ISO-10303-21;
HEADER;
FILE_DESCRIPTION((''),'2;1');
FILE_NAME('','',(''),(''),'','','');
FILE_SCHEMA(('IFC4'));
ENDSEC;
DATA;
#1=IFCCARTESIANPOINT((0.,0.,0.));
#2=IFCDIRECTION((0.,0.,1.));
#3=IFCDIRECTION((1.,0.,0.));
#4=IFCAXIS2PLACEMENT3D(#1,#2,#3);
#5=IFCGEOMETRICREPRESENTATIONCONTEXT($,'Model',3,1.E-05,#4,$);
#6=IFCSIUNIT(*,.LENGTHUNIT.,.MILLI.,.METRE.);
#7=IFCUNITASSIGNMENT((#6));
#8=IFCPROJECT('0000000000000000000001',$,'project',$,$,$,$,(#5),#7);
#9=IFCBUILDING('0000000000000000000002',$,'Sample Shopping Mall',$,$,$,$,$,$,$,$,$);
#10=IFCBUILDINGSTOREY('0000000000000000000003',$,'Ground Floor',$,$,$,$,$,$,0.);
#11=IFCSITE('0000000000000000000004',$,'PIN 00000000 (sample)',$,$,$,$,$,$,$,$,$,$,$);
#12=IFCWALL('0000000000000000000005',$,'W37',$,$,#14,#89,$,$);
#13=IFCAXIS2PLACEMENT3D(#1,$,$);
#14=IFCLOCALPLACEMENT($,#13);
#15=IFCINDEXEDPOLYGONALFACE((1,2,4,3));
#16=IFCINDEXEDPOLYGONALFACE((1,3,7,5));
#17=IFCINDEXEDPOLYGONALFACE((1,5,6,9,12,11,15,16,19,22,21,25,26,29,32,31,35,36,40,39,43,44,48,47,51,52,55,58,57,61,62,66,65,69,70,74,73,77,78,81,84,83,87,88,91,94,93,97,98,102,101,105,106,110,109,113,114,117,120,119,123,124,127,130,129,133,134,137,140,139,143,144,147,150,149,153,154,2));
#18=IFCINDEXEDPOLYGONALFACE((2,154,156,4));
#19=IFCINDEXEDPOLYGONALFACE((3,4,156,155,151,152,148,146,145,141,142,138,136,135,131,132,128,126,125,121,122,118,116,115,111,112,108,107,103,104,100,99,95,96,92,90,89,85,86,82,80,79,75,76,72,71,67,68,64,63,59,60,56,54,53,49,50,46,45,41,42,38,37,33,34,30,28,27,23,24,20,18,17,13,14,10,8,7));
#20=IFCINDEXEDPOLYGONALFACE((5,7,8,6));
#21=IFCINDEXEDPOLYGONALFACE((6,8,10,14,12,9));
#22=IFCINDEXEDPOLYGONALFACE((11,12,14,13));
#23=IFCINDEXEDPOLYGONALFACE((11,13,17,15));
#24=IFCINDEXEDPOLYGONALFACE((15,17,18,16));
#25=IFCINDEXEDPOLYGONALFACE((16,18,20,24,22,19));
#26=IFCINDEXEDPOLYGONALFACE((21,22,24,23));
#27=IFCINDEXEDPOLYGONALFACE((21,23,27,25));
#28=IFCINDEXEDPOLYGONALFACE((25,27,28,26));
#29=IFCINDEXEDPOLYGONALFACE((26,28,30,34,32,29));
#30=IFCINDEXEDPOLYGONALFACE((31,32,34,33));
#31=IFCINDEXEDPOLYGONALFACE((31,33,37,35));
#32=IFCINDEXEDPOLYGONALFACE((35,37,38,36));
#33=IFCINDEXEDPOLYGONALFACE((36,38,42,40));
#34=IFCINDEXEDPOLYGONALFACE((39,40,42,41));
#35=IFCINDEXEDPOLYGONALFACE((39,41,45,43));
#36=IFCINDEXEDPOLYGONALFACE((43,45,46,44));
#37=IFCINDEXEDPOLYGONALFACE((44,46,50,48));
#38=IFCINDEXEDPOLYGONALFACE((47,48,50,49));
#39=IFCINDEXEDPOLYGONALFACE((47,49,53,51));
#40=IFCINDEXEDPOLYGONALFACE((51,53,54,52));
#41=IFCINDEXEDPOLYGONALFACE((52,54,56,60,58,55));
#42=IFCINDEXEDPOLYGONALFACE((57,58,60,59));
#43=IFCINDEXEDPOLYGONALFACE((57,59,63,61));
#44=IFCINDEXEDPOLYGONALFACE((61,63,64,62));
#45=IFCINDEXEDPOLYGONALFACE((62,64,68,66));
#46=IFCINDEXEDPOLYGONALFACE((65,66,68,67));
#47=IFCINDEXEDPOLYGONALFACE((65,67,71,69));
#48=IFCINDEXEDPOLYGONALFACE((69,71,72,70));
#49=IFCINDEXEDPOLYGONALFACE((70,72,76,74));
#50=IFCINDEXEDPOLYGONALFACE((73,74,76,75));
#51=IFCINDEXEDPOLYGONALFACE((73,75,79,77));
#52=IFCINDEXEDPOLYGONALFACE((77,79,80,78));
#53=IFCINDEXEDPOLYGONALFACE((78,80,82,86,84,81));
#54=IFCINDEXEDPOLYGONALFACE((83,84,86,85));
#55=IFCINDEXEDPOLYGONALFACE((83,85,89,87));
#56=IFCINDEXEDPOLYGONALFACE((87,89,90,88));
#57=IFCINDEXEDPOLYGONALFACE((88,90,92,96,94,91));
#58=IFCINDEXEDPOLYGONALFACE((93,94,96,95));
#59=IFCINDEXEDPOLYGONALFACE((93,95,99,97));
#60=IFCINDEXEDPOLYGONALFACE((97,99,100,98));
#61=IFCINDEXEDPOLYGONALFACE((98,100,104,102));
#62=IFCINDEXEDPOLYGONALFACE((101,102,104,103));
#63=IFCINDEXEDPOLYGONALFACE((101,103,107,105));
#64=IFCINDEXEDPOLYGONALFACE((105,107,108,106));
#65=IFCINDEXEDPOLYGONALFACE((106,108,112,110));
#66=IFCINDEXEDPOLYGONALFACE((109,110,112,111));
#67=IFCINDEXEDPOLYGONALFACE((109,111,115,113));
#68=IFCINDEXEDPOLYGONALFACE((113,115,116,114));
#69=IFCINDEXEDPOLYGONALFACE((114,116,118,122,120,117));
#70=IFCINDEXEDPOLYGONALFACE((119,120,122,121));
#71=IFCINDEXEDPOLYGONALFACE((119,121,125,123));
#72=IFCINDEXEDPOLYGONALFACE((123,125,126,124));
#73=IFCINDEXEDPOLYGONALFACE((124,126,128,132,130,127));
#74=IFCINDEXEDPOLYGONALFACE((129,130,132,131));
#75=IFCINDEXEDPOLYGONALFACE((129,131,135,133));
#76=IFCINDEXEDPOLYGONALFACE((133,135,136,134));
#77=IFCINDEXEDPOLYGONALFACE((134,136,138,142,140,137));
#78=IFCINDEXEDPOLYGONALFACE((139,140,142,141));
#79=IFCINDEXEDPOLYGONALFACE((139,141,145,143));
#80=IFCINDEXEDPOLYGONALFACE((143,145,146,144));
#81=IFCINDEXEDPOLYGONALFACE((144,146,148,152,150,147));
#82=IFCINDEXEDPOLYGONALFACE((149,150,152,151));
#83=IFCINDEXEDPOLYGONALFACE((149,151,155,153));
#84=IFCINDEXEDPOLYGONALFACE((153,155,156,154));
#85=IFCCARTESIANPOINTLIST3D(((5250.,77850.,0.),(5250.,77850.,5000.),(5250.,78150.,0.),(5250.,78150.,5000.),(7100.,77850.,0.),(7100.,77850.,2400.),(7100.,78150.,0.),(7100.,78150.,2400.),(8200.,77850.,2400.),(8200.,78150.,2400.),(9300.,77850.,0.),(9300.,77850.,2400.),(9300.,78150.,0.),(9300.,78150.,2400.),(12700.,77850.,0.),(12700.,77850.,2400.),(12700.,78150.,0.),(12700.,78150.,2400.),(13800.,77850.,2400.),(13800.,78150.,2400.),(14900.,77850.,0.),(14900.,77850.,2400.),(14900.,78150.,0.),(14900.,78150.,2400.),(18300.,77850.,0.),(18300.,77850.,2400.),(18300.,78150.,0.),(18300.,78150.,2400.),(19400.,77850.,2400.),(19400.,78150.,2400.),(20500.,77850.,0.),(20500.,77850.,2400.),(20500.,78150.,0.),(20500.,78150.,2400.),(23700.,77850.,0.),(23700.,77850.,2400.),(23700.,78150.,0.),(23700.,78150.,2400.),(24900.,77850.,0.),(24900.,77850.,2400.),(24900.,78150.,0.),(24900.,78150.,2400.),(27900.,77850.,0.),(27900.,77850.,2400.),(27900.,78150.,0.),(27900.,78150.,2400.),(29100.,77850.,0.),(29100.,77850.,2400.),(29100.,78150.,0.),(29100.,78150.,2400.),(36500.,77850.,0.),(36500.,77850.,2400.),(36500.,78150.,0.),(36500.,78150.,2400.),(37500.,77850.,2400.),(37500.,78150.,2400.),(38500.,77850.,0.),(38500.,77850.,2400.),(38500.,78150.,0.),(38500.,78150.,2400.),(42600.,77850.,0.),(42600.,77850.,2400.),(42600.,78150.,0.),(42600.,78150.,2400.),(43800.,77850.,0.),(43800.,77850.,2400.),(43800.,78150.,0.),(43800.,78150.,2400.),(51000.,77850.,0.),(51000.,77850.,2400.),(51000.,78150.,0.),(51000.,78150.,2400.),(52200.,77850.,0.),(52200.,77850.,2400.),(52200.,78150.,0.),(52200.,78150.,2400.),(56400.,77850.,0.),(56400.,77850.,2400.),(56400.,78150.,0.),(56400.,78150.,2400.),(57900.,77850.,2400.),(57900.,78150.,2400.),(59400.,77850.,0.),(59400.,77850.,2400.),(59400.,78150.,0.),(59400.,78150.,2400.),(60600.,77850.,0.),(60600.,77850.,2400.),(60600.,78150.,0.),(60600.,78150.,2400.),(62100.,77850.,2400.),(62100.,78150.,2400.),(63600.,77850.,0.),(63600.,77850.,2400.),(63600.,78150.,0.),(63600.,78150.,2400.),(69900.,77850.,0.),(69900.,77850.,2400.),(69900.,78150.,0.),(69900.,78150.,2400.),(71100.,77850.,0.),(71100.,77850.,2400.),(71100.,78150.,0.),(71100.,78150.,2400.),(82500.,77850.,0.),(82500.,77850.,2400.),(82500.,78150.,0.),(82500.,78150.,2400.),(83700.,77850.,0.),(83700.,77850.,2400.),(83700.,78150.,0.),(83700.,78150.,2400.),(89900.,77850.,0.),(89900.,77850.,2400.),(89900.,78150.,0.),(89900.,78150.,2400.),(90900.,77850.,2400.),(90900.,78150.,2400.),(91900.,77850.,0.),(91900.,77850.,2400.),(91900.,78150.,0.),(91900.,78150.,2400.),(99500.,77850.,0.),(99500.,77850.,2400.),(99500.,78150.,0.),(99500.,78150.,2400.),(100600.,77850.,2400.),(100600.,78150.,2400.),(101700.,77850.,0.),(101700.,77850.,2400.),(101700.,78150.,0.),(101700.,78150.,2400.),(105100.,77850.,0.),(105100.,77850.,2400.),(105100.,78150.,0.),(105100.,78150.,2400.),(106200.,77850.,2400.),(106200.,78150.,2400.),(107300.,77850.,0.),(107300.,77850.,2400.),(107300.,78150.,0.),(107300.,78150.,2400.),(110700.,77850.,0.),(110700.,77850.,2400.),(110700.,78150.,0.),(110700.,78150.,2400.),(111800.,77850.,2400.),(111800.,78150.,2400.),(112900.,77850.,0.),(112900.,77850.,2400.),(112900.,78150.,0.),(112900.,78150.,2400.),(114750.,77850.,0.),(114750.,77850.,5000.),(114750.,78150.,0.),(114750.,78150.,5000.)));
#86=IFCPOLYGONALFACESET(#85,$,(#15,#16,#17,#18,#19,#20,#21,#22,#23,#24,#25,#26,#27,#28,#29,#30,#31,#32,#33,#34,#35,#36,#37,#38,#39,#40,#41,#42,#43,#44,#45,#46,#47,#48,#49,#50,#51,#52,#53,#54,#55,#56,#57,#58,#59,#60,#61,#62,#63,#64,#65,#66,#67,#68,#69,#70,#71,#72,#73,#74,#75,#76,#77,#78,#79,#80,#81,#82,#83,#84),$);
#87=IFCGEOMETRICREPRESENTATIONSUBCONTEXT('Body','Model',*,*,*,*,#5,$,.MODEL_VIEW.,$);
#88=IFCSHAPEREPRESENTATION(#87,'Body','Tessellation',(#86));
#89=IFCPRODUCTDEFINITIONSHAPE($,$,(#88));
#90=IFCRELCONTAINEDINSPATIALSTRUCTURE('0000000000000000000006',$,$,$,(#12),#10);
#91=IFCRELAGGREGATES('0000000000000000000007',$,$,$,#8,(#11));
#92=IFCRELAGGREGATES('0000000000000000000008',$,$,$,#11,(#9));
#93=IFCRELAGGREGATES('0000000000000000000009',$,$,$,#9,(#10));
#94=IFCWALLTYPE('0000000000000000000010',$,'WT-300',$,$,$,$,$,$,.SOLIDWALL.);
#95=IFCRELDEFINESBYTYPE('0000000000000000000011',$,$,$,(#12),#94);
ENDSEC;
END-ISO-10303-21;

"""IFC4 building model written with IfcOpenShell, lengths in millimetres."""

from ifc_helpers import new_model, si_unit, frame, origin_with_axes, place, context, subcontext, project, spatial, indexed_curve, outline, extrude, type_object, element, save


model = new_model("IFC4")

# Units and contexts
model_context = context("Model", 3, precision=1e-05, world=origin_with_axes())
body_context = subcontext(model_context, "Body", "Model", "MODEL_VIEW")
ifc_project = project(units=[si_unit("LENGTHUNIT", "METRE", prefix="MILLI")], contexts=[model_context])

# Site, building, storey
site = spatial("IfcSite", under=ifc_project, Name="PIN 00000000 (sample)")
building = spatial("IfcBuilding", under=site, Name="Sample Shopping Mall")
storey = spatial("IfcBuildingStorey", under=building, Name="Ground Floor", Elevation=0.0)

# Wall, openings
wall_type_1 = type_object("IfcWallType", Name="WT-300", PredefinedType="SOLIDWALL")
wall_1_placement = place(None, frame((5250.0, 77850.0, 0.0), z_axis=(0.0, 0.0, 1.0), x_axis=(1.0, 0.0, 0.0)))
wall_1 = element("IfcWall", 1, at=wall_1_placement, inside=storey, type_object=wall_type_1, Name="W37", context=body_context, shape_type="SweptSolid", body=[
    extrude(outline(indexed_curve([(0.0, 0.0), (0.0, 300.0), (109500.0, 300.0), (109500.0, 0.0), (0.0, 0.0)], self_intersect=False)), origin_with_axes(), (0.0, 0.0, 1.0), 5000.0),
])
opening_1_placement = place(wall_1_placement, frame((1850.0, -100.0, 0.0), z_axis=(0.0, 0.0, 1.0), x_axis=(1.0, 0.0, 0.0)))
element("IfcOpeningElement", 2, at=opening_1_placement, cuts=wall_1, context=body_context, shape_type="SweptSolid", body=[
    extrude(outline(indexed_curve([(0.0, 0.0), (0.0, 500.0), (1100.0, 500.0), (1100.0, 0.0), (0.0, 0.0)], self_intersect=False)), origin_with_axes(), (0.0, 0.0, 1.0), 2400.0),
])
opening_2_placement = place(wall_1_placement, frame((2950.0, -100.0, 0.0), z_axis=(0.0, 0.0, 1.0), x_axis=(1.0, 0.0, 0.0)))
element("IfcOpeningElement", 3, at=opening_2_placement, cuts=wall_1, context=body_context, shape_type="SweptSolid", body=[
    extrude(outline(indexed_curve([(0.0, 0.0), (0.0, 500.0), (1100.0, 500.0), (1100.0, 0.0), (0.0, 0.0)], self_intersect=False)), origin_with_axes(), (0.0, 0.0, 1.0), 2400.0),
])
opening_3_placement = place(wall_1_placement, frame((7450.0, -100.0, 0.0), z_axis=(0.0, 0.0, 1.0), x_axis=(1.0, 0.0, 0.0)))
element("IfcOpeningElement", 4, at=opening_3_placement, cuts=wall_1, context=body_context, shape_type="SweptSolid", body=[
    extrude(outline(indexed_curve([(0.0, 0.0), (0.0, 500.0), (1100.0, 500.0), (1100.0, 0.0), (0.0, 0.0)], self_intersect=False)), origin_with_axes(), (0.0, 0.0, 1.0), 2400.0),
])
opening_4_placement = place(wall_1_placement, frame((8550.0, -100.0, 0.0), z_axis=(0.0, 0.0, 1.0), x_axis=(1.0, 0.0, 0.0)))
element("IfcOpeningElement", 5, at=opening_4_placement, cuts=wall_1, context=body_context, shape_type="SweptSolid", body=[
    extrude(outline(indexed_curve([(0.0, 0.0), (0.0, 500.0), (1100.0, 500.0), (1100.0, 0.0), (0.0, 0.0)], self_intersect=False)), origin_with_axes(), (0.0, 0.0, 1.0), 2400.0),
])
opening_5_placement = place(wall_1_placement, frame((13050.0, -100.0, 0.0), z_axis=(0.0, 0.0, 1.0), x_axis=(1.0, 0.0, 0.0)))
element("IfcOpeningElement", 6, at=opening_5_placement, cuts=wall_1, context=body_context, shape_type="SweptSolid", body=[
    extrude(outline(indexed_curve([(0.0, 0.0), (0.0, 500.0), (1100.0, 500.0), (1100.0, 0.0), (0.0, 0.0)], self_intersect=False)), origin_with_axes(), (0.0, 0.0, 1.0), 2400.0),
])
opening_6_placement = place(wall_1_placement, frame((14150.0, -100.0, 0.0), z_axis=(0.0, 0.0, 1.0), x_axis=(1.0, 0.0, 0.0)))
element("IfcOpeningElement", 7, at=opening_6_placement, cuts=wall_1, context=body_context, shape_type="SweptSolid", body=[
    extrude(outline(indexed_curve([(0.0, 0.0), (0.0, 500.0), (1100.0, 500.0), (1100.0, 0.0), (0.0, 0.0)], self_intersect=False)), origin_with_axes(), (0.0, 0.0, 1.0), 2400.0),
])
opening_7_placement = place(wall_1_placement, frame((94250.0, -100.0, 0.0), z_axis=(0.0, 0.0, 1.0), x_axis=(1.0, 0.0, 0.0)))
element("IfcOpeningElement", 8, at=opening_7_placement, cuts=wall_1, context=body_context, shape_type="SweptSolid", body=[
    extrude(outline(indexed_curve([(0.0, 0.0), (0.0, 500.0), (1100.0, 500.0), (1100.0, 0.0), (0.0, 0.0)], self_intersect=False)), origin_with_axes(), (0.0, 0.0, 1.0), 2400.0),
])
opening_8_placement = place(wall_1_placement, frame((95350.0, -100.0, 0.0), z_axis=(0.0, 0.0, 1.0), x_axis=(1.0, 0.0, 0.0)))
element("IfcOpeningElement", 9, at=opening_8_placement, cuts=wall_1, context=body_context, shape_type="SweptSolid", body=[
    extrude(outline(indexed_curve([(0.0, 0.0), (0.0, 500.0), (1100.0, 500.0), (1100.0, 0.0), (0.0, 0.0)], self_intersect=False)), origin_with_axes(), (0.0, 0.0, 1.0), 2400.0),
])
opening_9_placement = place(wall_1_placement, frame((99850.0, -100.0, 0.0), z_axis=(0.0, 0.0, 1.0), x_axis=(1.0, 0.0, 0.0)))
element("IfcOpeningElement", 10, at=opening_9_placement, cuts=wall_1, context=body_context, shape_type="SweptSolid", body=[
    extrude(outline(indexed_curve([(0.0, 0.0), (0.0, 500.0), (1100.0, 500.0), (1100.0, 0.0), (0.0, 0.0)], self_intersect=False)), origin_with_axes(), (0.0, 0.0, 1.0), 2400.0),
])
opening_10_placement = place(wall_1_placement, frame((100950.0, -100.0, 0.0), z_axis=(0.0, 0.0, 1.0), x_axis=(1.0, 0.0, 0.0)))
element("IfcOpeningElement", 11, at=opening_10_placement, cuts=wall_1, context=body_context, shape_type="SweptSolid", body=[
    extrude(outline(indexed_curve([(0.0, 0.0), (0.0, 500.0), (1100.0, 500.0), (1100.0, 0.0), (0.0, 0.0)], self_intersect=False)), origin_with_axes(), (0.0, 0.0, 1.0), 2400.0),
])
opening_11_placement = place(wall_1_placement, frame((105450.0, -100.0, 0.0), z_axis=(0.0, 0.0, 1.0), x_axis=(1.0, 0.0, 0.0)))
element("IfcOpeningElement", 12, at=opening_11_placement, cuts=wall_1, context=body_context, shape_type="SweptSolid", body=[
    extrude(outline(indexed_curve([(0.0, 0.0), (0.0, 500.0), (1100.0, 500.0), (1100.0, 0.0), (0.0, 0.0)], self_intersect=False)), origin_with_axes(), (0.0, 0.0, 1.0), 2400.0),
])
opening_12_placement = place(wall_1_placement, frame((106550.0, -100.0, 0.0), z_axis=(0.0, 0.0, 1.0), x_axis=(1.0, 0.0, 0.0)))
element("IfcOpeningElement", 13, at=opening_12_placement, cuts=wall_1, context=body_context, shape_type="SweptSolid", body=[
    extrude(outline(indexed_curve([(0.0, 0.0), (0.0, 500.0), (1100.0, 500.0), (1100.0, 0.0), (0.0, 0.0)], self_intersect=False)), origin_with_axes(), (0.0, 0.0, 1.0), 2400.0),
])
opening_13_placement = place(wall_1_placement, frame((18450.0, -100.0, 0.0), z_axis=(0.0, 0.0, 1.0), x_axis=(1.0, 0.0, 0.0)))
element("IfcOpeningElement", 14, at=opening_13_placement, cuts=wall_1, context=body_context, shape_type="SweptSolid", body=[
    extrude(outline(indexed_curve([(0.0, 0.0), (0.0, 500.0), (1200.0, 500.0), (1200.0, 0.0), (0.0, 0.0)], self_intersect=False)), origin_with_axes(), (0.0, 0.0, 1.0), 2400.0),
])
opening_14_placement = place(wall_1_placement, frame((22650.0, -100.0, 0.0), z_axis=(0.0, 0.0, 1.0), x_axis=(1.0, 0.0, 0.0)))
element("IfcOpeningElement", 15, at=opening_14_placement, cuts=wall_1, context=body_context, shape_type="SweptSolid", body=[
    extrude(outline(indexed_curve([(0.0, 0.0), (0.0, 500.0), (1200.0, 500.0), (1200.0, 0.0), (0.0, 0.0)], self_intersect=False)), origin_with_axes(), (0.0, 0.0, 1.0), 2400.0),
])
opening_15_placement = place(wall_1_placement, frame((37350.0, -100.0, 0.0), z_axis=(0.0, 0.0, 1.0), x_axis=(1.0, 0.0, 0.0)))
element("IfcOpeningElement", 16, at=opening_15_placement, cuts=wall_1, context=body_context, shape_type="SweptSolid", body=[
    extrude(outline(indexed_curve([(0.0, 0.0), (0.0, 500.0), (1200.0, 500.0), (1200.0, 0.0), (0.0, 0.0)], self_intersect=False)), origin_with_axes(), (0.0, 0.0, 1.0), 2400.0),
])
opening_16_placement = place(wall_1_placement, frame((45750.0, -100.0, 0.0), z_axis=(0.0, 0.0, 1.0), x_axis=(1.0, 0.0, 0.0)))
element("IfcOpeningElement", 17, at=opening_16_placement, cuts=wall_1, context=body_context, shape_type="SweptSolid", body=[
    extrude(outline(indexed_curve([(0.0, 0.0), (0.0, 500.0), (1200.0, 500.0), (1200.0, 0.0), (0.0, 0.0)], self_intersect=False)), origin_with_axes(), (0.0, 0.0, 1.0), 2400.0),
])
opening_17_placement = place(wall_1_placement, frame((64650.0, -100.0, 0.0), z_axis=(0.0, 0.0, 1.0), x_axis=(1.0, 0.0, 0.0)))
element("IfcOpeningElement", 18, at=opening_17_placement, cuts=wall_1, context=body_context, shape_type="SweptSolid", body=[
    extrude(outline(indexed_curve([(0.0, 0.0), (0.0, 500.0), (1200.0, 500.0), (1200.0, 0.0), (0.0, 0.0)], self_intersect=False)), origin_with_axes(), (0.0, 0.0, 1.0), 2400.0),
])
opening_18_placement = place(wall_1_placement, frame((77250.0, -100.0, 0.0), z_axis=(0.0, 0.0, 1.0), x_axis=(1.0, 0.0, 0.0)))
element("IfcOpeningElement", 19, at=opening_18_placement, cuts=wall_1, context=body_context, shape_type="SweptSolid", body=[
    extrude(outline(indexed_curve([(0.0, 0.0), (0.0, 500.0), (1200.0, 500.0), (1200.0, 0.0), (0.0, 0.0)], self_intersect=False)), origin_with_axes(), (0.0, 0.0, 1.0), 2400.0),
])
opening_19_placement = place(wall_1_placement, frame((31250.0, -100.0, 0.0), z_axis=(0.0, 0.0, 1.0), x_axis=(1.0, 0.0, 0.0)))
element("IfcOpeningElement", 20, at=opening_19_placement, cuts=wall_1, context=body_context, shape_type="SweptSolid", body=[
    extrude(outline(indexed_curve([(0.0, 0.0), (0.0, 500.0), (1000.0, 500.0), (1000.0, 0.0), (0.0, 0.0)], self_intersect=False)), origin_with_axes(), (0.0, 0.0, 1.0), 2400.0),
])
opening_20_placement = place(wall_1_placement, frame((32250.0, -100.0, 0.0), z_axis=(0.0, 0.0, 1.0), x_axis=(1.0, 0.0, 0.0)))
element("IfcOpeningElement", 21, at=opening_20_placement, cuts=wall_1, context=body_context, shape_type="SweptSolid", body=[
    extrude(outline(indexed_curve([(0.0, 0.0), (0.0, 500.0), (1000.0, 500.0), (1000.0, 0.0), (0.0, 0.0)], self_intersect=False)), origin_with_axes(), (0.0, 0.0, 1.0), 2400.0),
])
opening_21_placement = place(wall_1_placement, frame((51150.0, -100.0, 0.0), z_axis=(0.0, 0.0, 1.0), x_axis=(1.0, 0.0, 0.0)))
element("IfcOpeningElement", 22, at=opening_21_placement, cuts=wall_1, context=body_context, shape_type="SweptSolid", body=[
    extrude(outline(indexed_curve([(0.0, 0.0), (0.0, 500.0), (1500.0, 500.0), (1500.0, 0.0), (0.0, 0.0)], self_intersect=False)), origin_with_axes(), (0.0, 0.0, 1.0), 2400.0),
])
opening_22_placement = place(wall_1_placement, frame((52650.0, -100.0, 0.0), z_axis=(0.0, 0.0, 1.0), x_axis=(1.0, 0.0, 0.0)))
element("IfcOpeningElement", 23, at=opening_22_placement, cuts=wall_1, context=body_context, shape_type="SweptSolid", body=[
    extrude(outline(indexed_curve([(0.0, 0.0), (0.0, 500.0), (1500.0, 500.0), (1500.0, 0.0), (0.0, 0.0)], self_intersect=False)), origin_with_axes(), (0.0, 0.0, 1.0), 2400.0),
])
opening_23_placement = place(wall_1_placement, frame((55350.0, -100.0, 0.0), z_axis=(0.0, 0.0, 1.0), x_axis=(1.0, 0.0, 0.0)))
element("IfcOpeningElement", 24, at=opening_23_placement, cuts=wall_1, context=body_context, shape_type="SweptSolid", body=[
    extrude(outline(indexed_curve([(0.0, 0.0), (0.0, 500.0), (1500.0, 500.0), (1500.0, 0.0), (0.0, 0.0)], self_intersect=False)), origin_with_axes(), (0.0, 0.0, 1.0), 2400.0),
])
opening_24_placement = place(wall_1_placement, frame((56850.0, -100.0, 0.0), z_axis=(0.0, 0.0, 1.0), x_axis=(1.0, 0.0, 0.0)))
element("IfcOpeningElement", 25, at=opening_24_placement, cuts=wall_1, context=body_context, shape_type="SweptSolid", body=[
    extrude(outline(indexed_curve([(0.0, 0.0), (0.0, 500.0), (1500.0, 500.0), (1500.0, 0.0), (0.0, 0.0)], self_intersect=False)), origin_with_axes(), (0.0, 0.0, 1.0), 2400.0),
])
opening_25_placement = place(wall_1_placement, frame((84650.0, -100.0, 0.0), z_axis=(0.0, 0.0, 1.0), x_axis=(1.0, 0.0, 0.0)))
element("IfcOpeningElement", 26, at=opening_25_placement, cuts=wall_1, context=body_context, shape_type="SweptSolid", body=[
    extrude(outline(indexed_curve([(0.0, 0.0), (0.0, 500.0), (1000.0, 500.0), (1000.0, 0.0), (0.0, 0.0)], self_intersect=False)), origin_with_axes(), (0.0, 0.0, 1.0), 2400.0),
])
opening_26_placement = place(wall_1_placement, frame((85650.0, -100.0, 0.0), z_axis=(0.0, 0.0, 1.0), x_axis=(1.0, 0.0, 0.0)))
element("IfcOpeningElement", 27, at=opening_26_placement, cuts=wall_1, context=body_context, shape_type="SweptSolid", body=[
    extrude(outline(indexed_curve([(0.0, 0.0), (0.0, 500.0), (1000.0, 500.0), (1000.0, 0.0), (0.0, 0.0)], self_intersect=False)), origin_with_axes(), (0.0, 0.0, 1.0), 2400.0),
])

save(model, "model.ifc")
